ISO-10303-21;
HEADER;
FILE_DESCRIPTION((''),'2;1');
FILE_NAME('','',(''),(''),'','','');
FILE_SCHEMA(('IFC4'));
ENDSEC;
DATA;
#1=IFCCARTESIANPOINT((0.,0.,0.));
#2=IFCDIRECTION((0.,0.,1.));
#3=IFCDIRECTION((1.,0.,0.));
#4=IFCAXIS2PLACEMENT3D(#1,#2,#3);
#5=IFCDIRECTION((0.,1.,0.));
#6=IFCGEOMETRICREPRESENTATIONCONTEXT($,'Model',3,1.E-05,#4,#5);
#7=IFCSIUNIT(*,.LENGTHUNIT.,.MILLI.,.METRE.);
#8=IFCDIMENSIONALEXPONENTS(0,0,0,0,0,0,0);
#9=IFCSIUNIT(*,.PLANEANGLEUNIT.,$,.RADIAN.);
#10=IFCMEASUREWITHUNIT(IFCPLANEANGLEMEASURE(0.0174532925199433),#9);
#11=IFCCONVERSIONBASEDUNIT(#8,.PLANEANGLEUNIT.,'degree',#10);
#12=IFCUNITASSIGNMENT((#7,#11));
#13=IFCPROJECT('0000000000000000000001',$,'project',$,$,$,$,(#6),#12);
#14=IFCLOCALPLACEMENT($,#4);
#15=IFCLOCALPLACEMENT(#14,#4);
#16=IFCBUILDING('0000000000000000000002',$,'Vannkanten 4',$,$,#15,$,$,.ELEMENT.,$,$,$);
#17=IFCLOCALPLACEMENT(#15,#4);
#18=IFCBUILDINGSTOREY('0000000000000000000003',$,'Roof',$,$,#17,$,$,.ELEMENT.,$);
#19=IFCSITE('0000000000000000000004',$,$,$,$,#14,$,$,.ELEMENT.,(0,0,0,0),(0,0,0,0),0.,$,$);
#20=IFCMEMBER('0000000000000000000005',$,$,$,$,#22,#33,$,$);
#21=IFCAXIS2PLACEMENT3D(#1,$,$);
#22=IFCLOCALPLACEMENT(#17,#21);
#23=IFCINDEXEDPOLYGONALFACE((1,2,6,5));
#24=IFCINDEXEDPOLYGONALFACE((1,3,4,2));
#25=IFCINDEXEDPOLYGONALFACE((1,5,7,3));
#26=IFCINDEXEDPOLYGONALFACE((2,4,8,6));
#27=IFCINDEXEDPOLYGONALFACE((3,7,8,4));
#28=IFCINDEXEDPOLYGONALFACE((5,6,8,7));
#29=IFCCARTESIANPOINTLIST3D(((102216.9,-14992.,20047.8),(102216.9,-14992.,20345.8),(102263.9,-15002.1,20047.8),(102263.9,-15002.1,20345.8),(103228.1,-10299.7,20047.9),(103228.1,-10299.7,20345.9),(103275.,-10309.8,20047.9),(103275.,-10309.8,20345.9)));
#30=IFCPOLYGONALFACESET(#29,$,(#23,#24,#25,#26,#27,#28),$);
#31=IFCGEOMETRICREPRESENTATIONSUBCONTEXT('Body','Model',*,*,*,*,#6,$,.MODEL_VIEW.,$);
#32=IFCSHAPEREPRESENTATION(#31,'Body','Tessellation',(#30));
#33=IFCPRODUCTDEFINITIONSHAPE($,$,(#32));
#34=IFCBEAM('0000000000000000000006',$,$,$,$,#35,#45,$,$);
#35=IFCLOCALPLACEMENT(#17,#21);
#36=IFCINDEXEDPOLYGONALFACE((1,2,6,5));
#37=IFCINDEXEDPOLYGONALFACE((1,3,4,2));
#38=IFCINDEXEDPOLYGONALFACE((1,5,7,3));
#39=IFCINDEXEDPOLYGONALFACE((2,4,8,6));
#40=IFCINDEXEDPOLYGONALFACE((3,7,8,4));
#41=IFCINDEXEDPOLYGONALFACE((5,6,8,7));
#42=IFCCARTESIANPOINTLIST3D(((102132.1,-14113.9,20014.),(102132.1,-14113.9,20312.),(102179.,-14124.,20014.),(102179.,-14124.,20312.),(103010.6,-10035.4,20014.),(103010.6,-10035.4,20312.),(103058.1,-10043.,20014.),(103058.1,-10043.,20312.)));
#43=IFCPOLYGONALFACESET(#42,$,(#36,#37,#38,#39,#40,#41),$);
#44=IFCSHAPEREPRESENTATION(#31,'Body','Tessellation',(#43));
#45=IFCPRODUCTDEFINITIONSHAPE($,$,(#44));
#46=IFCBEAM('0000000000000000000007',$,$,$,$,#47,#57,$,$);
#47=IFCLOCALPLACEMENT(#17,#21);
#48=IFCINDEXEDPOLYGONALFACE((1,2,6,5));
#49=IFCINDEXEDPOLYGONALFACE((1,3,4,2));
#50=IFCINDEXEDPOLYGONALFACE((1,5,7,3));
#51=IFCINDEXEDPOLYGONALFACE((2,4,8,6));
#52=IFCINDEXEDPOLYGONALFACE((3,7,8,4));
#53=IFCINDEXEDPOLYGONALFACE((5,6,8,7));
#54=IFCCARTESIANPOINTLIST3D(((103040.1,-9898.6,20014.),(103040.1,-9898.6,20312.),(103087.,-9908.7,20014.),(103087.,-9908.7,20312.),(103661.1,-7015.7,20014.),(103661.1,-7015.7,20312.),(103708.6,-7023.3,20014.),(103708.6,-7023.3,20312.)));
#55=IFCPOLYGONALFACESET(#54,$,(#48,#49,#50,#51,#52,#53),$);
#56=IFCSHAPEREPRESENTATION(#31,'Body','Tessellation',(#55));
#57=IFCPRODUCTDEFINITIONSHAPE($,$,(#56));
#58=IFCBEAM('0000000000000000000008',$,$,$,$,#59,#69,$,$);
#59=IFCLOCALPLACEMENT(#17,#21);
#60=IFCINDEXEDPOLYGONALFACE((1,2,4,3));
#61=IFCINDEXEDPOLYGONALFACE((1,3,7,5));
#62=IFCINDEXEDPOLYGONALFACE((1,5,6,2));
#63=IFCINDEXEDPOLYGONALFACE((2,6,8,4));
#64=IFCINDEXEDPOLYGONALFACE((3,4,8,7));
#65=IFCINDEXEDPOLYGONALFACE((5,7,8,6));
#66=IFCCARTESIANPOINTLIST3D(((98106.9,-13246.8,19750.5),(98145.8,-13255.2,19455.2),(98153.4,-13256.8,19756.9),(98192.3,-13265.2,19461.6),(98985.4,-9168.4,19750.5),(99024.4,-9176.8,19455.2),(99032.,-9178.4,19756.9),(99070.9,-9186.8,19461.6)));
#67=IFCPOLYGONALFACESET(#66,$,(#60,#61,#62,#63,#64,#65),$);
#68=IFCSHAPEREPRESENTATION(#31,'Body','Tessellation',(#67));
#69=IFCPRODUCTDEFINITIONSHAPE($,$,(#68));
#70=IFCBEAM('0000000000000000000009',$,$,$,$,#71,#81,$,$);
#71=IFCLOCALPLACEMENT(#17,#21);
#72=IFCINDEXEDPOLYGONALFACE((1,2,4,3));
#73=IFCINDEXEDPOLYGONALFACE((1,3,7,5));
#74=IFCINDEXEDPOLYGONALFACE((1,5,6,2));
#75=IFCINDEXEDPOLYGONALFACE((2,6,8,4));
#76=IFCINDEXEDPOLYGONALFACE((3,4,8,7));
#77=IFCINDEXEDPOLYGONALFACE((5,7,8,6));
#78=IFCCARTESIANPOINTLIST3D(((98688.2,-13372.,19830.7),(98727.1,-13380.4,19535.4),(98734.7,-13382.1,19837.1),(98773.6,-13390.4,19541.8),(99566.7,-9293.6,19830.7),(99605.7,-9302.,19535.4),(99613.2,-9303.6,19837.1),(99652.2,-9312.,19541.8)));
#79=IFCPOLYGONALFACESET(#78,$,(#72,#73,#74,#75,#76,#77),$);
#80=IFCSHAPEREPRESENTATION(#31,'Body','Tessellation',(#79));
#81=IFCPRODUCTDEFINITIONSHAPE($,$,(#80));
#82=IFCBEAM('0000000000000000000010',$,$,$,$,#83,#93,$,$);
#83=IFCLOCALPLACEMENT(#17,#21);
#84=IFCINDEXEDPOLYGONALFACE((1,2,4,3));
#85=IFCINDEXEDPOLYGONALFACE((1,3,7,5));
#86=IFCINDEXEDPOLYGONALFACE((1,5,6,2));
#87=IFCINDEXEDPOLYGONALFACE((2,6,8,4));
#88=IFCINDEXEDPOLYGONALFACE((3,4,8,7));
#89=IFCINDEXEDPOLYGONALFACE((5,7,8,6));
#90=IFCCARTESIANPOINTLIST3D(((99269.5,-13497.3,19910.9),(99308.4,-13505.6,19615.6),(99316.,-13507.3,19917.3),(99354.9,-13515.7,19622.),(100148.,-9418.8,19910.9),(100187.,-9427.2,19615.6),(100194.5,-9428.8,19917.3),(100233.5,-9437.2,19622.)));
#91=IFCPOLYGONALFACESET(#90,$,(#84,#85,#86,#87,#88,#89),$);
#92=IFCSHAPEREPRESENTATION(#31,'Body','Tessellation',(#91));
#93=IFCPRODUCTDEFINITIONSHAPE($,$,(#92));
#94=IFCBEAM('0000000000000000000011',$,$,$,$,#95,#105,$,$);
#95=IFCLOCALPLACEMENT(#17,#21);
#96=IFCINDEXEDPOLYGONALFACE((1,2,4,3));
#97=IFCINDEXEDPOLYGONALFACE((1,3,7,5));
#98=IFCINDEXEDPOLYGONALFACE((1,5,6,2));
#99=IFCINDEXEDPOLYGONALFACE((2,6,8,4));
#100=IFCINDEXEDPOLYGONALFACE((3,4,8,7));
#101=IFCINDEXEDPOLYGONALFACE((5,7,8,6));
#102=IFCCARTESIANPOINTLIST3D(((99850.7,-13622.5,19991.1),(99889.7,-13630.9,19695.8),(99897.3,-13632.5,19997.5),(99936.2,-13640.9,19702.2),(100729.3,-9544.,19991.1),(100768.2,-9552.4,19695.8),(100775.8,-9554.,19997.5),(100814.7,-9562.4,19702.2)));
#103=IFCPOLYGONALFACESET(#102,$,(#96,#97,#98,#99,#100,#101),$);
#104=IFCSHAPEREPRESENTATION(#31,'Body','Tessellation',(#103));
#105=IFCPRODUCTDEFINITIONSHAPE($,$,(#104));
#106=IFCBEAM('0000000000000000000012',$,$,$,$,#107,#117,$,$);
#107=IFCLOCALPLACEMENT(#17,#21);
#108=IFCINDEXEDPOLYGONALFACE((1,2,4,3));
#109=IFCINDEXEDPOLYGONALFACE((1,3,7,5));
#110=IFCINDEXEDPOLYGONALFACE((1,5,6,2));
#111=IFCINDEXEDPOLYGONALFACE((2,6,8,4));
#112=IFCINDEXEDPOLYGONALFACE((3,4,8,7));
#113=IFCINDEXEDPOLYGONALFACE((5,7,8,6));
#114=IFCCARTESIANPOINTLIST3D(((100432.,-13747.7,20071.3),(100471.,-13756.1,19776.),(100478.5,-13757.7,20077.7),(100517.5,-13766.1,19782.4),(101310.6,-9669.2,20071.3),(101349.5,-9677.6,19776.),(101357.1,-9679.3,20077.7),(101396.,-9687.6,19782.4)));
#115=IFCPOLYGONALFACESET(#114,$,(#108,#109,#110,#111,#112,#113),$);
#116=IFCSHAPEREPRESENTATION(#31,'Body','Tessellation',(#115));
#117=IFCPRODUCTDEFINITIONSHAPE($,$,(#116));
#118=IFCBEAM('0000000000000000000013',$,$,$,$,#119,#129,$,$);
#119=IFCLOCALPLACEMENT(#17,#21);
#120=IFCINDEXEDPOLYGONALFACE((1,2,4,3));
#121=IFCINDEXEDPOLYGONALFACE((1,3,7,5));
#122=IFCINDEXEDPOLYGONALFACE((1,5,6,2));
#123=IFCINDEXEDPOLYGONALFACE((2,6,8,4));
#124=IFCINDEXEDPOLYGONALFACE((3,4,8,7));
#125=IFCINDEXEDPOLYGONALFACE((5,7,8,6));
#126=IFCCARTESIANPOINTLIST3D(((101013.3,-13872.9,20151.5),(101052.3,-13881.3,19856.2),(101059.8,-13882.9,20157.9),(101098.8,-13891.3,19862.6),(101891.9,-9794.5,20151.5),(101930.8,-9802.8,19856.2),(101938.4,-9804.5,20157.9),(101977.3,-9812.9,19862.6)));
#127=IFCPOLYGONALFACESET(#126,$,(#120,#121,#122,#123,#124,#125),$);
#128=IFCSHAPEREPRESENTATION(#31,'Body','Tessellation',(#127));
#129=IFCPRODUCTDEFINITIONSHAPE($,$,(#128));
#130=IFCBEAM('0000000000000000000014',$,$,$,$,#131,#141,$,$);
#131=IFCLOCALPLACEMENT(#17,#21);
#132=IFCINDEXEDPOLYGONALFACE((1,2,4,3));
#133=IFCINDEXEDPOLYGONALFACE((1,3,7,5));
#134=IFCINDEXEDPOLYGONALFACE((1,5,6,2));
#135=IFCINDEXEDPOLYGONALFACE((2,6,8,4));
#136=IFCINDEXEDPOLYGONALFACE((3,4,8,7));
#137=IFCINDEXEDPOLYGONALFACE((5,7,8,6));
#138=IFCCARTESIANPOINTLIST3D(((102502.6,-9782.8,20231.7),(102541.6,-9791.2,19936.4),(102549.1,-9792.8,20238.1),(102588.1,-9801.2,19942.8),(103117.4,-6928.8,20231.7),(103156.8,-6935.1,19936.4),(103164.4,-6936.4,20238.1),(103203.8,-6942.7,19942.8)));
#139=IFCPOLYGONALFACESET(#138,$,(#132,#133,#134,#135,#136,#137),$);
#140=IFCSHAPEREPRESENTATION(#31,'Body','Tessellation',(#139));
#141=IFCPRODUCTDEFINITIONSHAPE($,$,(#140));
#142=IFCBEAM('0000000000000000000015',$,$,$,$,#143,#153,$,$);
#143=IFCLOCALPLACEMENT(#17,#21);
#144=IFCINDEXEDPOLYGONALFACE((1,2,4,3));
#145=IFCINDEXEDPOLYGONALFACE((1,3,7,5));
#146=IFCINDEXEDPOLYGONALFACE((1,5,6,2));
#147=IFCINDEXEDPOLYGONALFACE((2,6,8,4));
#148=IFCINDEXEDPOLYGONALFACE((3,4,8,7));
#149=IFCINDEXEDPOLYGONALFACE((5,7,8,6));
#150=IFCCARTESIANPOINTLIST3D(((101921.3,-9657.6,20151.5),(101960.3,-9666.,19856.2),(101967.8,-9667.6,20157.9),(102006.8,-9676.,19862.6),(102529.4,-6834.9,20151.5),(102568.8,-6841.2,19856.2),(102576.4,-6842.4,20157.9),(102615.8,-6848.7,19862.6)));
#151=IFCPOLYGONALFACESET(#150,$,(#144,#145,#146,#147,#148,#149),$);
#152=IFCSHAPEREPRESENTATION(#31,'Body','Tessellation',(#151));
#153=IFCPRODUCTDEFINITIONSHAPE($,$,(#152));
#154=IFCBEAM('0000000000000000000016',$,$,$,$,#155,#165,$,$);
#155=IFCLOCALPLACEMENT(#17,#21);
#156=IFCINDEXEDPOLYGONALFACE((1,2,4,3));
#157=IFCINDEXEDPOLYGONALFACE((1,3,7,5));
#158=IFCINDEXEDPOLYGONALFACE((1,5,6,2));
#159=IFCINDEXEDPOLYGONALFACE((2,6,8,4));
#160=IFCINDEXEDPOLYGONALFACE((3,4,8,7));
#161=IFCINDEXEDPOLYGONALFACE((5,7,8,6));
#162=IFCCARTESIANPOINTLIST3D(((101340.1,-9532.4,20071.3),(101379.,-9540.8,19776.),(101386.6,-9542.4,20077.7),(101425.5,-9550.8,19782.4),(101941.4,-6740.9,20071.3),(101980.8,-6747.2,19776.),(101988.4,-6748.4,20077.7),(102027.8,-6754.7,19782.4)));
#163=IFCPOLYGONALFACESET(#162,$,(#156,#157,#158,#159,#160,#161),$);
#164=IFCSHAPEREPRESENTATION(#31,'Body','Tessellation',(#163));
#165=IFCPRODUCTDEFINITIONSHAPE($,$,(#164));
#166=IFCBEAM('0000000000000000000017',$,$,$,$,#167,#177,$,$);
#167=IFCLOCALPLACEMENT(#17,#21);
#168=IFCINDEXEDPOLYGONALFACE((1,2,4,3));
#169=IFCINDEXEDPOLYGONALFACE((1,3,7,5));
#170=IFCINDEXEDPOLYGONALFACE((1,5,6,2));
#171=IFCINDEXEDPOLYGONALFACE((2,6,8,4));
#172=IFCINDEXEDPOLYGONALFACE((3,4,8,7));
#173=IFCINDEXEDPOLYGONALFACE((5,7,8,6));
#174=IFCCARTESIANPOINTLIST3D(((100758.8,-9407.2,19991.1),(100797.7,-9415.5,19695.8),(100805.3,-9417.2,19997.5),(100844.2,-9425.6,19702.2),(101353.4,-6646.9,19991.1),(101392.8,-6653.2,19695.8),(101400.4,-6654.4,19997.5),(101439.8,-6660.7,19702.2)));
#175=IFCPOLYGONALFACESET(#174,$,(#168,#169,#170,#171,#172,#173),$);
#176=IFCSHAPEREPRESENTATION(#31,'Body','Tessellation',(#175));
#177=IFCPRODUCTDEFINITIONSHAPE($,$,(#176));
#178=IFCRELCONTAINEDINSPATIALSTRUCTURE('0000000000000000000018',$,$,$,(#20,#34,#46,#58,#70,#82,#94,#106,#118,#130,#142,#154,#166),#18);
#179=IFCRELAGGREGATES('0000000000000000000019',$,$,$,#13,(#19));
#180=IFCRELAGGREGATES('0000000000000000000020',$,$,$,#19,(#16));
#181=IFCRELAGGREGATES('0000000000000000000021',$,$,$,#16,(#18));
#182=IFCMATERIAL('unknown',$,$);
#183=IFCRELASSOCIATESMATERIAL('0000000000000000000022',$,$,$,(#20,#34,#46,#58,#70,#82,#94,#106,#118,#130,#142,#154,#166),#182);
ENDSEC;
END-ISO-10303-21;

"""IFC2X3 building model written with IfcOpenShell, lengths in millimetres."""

from ifc_helpers import new_model, entity, si_unit, converted_unit, direction, frame, origin_with_axes, place, context, subcontext, project, spatial, polyline, segment, composite_curve, outline, extrude, clip, halfspace, material, element, save


model = new_model("IFC2X3")

# Units and contexts
model_context = context("Model", 3, precision=1e-05, world=origin_with_axes(), true_north=direction((0.0, 1.0, 0.0)))
body_context = subcontext(model_context, "Body", "Model", "MODEL_VIEW")
ifc_project = project(units=[si_unit("LENGTHUNIT", "METRE", prefix="MILLI"), converted_unit("PLANEANGLEUNIT", "degree", entity("IfcPlaneAngleMeasure", 0.0174532925199433), si_unit("PLANEANGLEUNIT", "RADIAN"), dimensions=[0, 0, 0, 0, 0, 0, 0])], contexts=[model_context])

# Site, building, storey
site_placement = place(None, origin_with_axes())
site = spatial("IfcSite", under=ifc_project, at=site_placement, CompositionType="ELEMENT", RefLatitude=(0, 0, 0, 0), RefLongitude=(0, 0, 0, 0), RefElevation=0.0)
building_placement = place(site_placement, origin_with_axes())
building = spatial("IfcBuilding", under=site, at=building_placement, Name="Vannkanten 4", CompositionType="ELEMENT")
storey_placement = place(building_placement, origin_with_axes())
storey = spatial("IfcBuildingStorey", under=building, at=storey_placement, Name="Roof", CompositionType="ELEMENT")

# Member
ifc_material = material(Name="unknown")
member_1_placement = place(storey_placement, frame((103251.6, -10304.7, 20196.9), z_axis=(-0.210663, -0.977559, -0.000011), x_axis=(0.977559, -0.210663, 0.0)))
element("IfcMember", 1, at=member_1_placement, inside=storey, material=ifc_material, context=body_context, shape_type="SweptSolid", body=[
    extrude(outline(composite_curve([segment(polyline([(-24.0, -149.0), (-24.0, 149.0), (24.0, 149.0), (24.0, -149.0), (-24.0, -149.0)]), True, "CONTINUOUS")], self_intersect=False)), frame((0.0, 0.0, 0.0), z_axis=(0.0, 0.0, 1.0), x_axis=(1.0, 0.0, 0.0)), (0.0, 0.0, 1.0), 4800.0),
])

# Beams
beam_1_placement = place(storey_placement, frame((103034.4, -10039.2, 20163.0), z_axis=(-0.210582, -0.977576, 0.0), x_axis=(0.977576, -0.210582, 0.0)))
element("IfcBeam", 2, at=beam_1_placement, inside=storey, material=ifc_material, context=body_context, shape_type="Clipping", body=[
    clip(extrude(outline(composite_curve([segment(polyline([(-24.0, -149.0), (-24.0, 149.0), (24.0, 149.0), (24.0, -149.0), (-24.0, -149.0)]), True, "CONTINUOUS")], self_intersect=False)), frame((0.0, 0.0, -2088.6), z_axis=(0.0, 0.0, 1.0), x_axis=(1.0, 0.0, 0.0)), (0.0, 0.0, 1.0), 6261.9), halfspace(frame((-24.0, 149.0, 1.3), z_axis=(0.053649, 0.0, 0.99856), x_axis=(0.99856, 0.0, -0.053649)), True)),
])
beam_2_placement = place(storey_placement, frame((103684.8, -7019.5, 20163.0), z_axis=(-0.210582, -0.977576, 0.0), x_axis=(0.977576, -0.210582, 0.0)))
element("IfcBeam", 3, at=beam_2_placement, inside=storey, material=ifc_material, context=body_context, shape_type="Clipping", body=[
    clip(extrude(outline(composite_curve([segment(polyline([(-24.0, -149.0), (-24.0, 149.0), (24.0, 149.0), (24.0, -149.0), (-24.0, -149.0)]), True, "CONTINUOUS")], self_intersect=False)), frame((0.0, 0.0, -1477.1), z_axis=(0.0, 0.0, 1.0), x_axis=(1.0, 0.0, 0.0)), (0.0, 0.0, 1.0), 4427.3), halfspace(frame((-24.0, 149.0, 1.3), z_axis=(0.053649, 0.0, 0.99856), x_axis=(0.99856, 0.0, -0.053649)), True)),
])
beam_3_placement = place(storey_placement, frame((98149.6, -13256.0, 19606.0), z_axis=(0.210582, 0.977576, 0.0), x_axis=(-0.968803, 0.208692, -0.133675)))
element("IfcBeam", 4, at=beam_3_placement, inside=storey, material=ifc_material, context=body_context, shape_type="SweptSolid", body=[
    extrude(outline(composite_curve([segment(polyline([(-24.0, -149.0), (-24.0, 149.0), (24.0, 149.0), (24.0, -149.0), (-24.0, -149.0)]), True, "CONTINUOUS")], self_intersect=False)), frame((0.0, 0.0, 0.0), z_axis=(0.0, 0.0, 1.0), x_axis=(1.0, 0.0, 0.0)), (0.0, 0.0, 1.0), 4172.0),
])
beam_4_placement = place(storey_placement, frame((98730.9, -13381.2, 19686.2), z_axis=(0.210582, 0.977576, 0.0), x_axis=(-0.968803, 0.208692, -0.133675)))
element("IfcBeam", 5, at=beam_4_placement, inside=storey, material=ifc_material, context=body_context, shape_type="SweptSolid", body=[
    extrude(outline(composite_curve([segment(polyline([(-24.0, -149.0), (-24.0, 149.0), (24.0, 149.0), (24.0, -149.0), (-24.0, -149.0)]), True, "CONTINUOUS")], self_intersect=False)), frame((0.0, 0.0, 0.0), z_axis=(0.0, 0.0, 1.0), x_axis=(1.0, 0.0, 0.0)), (0.0, 0.0, 1.0), 4172.0),
])
beam_5_placement = place(storey_placement, frame((99312.2, -13506.5, 19766.5), z_axis=(0.210582, 0.977576, 0.0), x_axis=(-0.968803, 0.208692, -0.133675)))
element("IfcBeam", 6, at=beam_5_placement, inside=storey, material=ifc_material, context=body_context, shape_type="SweptSolid", body=[
    extrude(outline(composite_curve([segment(polyline([(-24.0, -149.0), (-24.0, 149.0), (24.0, 149.0), (24.0, -149.0), (-24.0, -149.0)]), True, "CONTINUOUS")], self_intersect=False)), frame((0.0, 0.0, 0.0), z_axis=(0.0, 0.0, 1.0), x_axis=(1.0, 0.0, 0.0)), (0.0, 0.0, 1.0), 4172.0),
])
beam_6_placement = place(storey_placement, frame((99893.5, -13631.7, 19846.7), z_axis=(0.210582, 0.977576, 0.0), x_axis=(-0.968803, 0.208692, -0.133675)))
element("IfcBeam", 7, at=beam_6_placement, inside=storey, material=ifc_material, context=body_context, shape_type="SweptSolid", body=[
    extrude(outline(composite_curve([segment(polyline([(-24.0, -149.0), (-24.0, 149.0), (24.0, 149.0), (24.0, -149.0), (-24.0, -149.0)]), True, "CONTINUOUS")], self_intersect=False)), frame((0.0, 0.0, 0.0), z_axis=(0.0, 0.0, 1.0), x_axis=(1.0, 0.0, 0.0)), (0.0, 0.0, 1.0), 4172.0),
])
beam_7_placement = place(storey_placement, frame((100474.8, -13756.9, 19926.9), z_axis=(0.210582, 0.977576, 0.0), x_axis=(-0.968803, 0.208692, -0.133675)))
element("IfcBeam", 8, at=beam_7_placement, inside=storey, material=ifc_material, context=body_context, shape_type="SweptSolid", body=[
    extrude(outline(composite_curve([segment(polyline([(-24.0, -149.0), (-24.0, 149.0), (24.0, 149.0), (24.0, -149.0), (-24.0, -149.0)]), True, "CONTINUOUS")], self_intersect=False)), frame((0.0, 0.0, 0.0), z_axis=(0.0, 0.0, 1.0), x_axis=(1.0, 0.0, 0.0)), (0.0, 0.0, 1.0), 4172.0),
])
beam_8_placement = place(storey_placement, frame((101056.0, -13882.1, 20007.1), z_axis=(0.210582, 0.977576, 0.0), x_axis=(-0.968803, 0.208692, -0.133675)))
element("IfcBeam", 9, at=beam_8_placement, inside=storey, material=ifc_material, context=body_context, shape_type="SweptSolid", body=[
    extrude(outline(composite_curve([segment(polyline([(-24.0, -149.0), (-24.0, 149.0), (24.0, 149.0), (24.0, -149.0), (-24.0, -149.0)]), True, "CONTINUOUS")], self_intersect=False)), frame((0.0, 0.0, 0.0), z_axis=(0.0, 0.0, 1.0), x_axis=(1.0, 0.0, 0.0)), (0.0, 0.0, 1.0), 4172.0),
])
beam_9_placement = place(storey_placement, frame((102545.3, -9792.0, 20087.3), z_axis=(0.210582, 0.977576, 0.0), x_axis=(-0.968803, 0.208692, -0.133675)))
element("IfcBeam", 10, at=beam_9_placement, inside=storey, material=ifc_material, context=body_context, shape_type="Clipping", body=[
    clip(extrude(outline(composite_curve([segment(polyline([(-24.0, -149.0), (-24.0, 149.0), (24.0, 149.0), (24.0, -149.0), (-24.0, -149.0)]), True, "CONTINUOUS")], self_intersect=False)), frame((0.0, 0.0, 0.0), z_axis=(0.0, 0.0, 1.0), x_axis=(1.0, 0.0, 0.0)), (0.0, 0.0, 1.0), 4386.2), halfspace(frame((-24.0, -149.0, 2924.1), z_axis=(-0.053168, -0.007172, -0.99856), x_axis=(-0.998586, 0.0, 0.053169)), True)),
])
beam_10_placement = place(storey_placement, frame((101964.1, -9666.8, 20007.1), z_axis=(0.210582, 0.977576, 0.0), x_axis=(-0.968803, 0.208692, -0.133675)))
element("IfcBeam", 11, at=beam_10_placement, inside=storey, material=ifc_material, context=body_context, shape_type="Clipping", body=[
    clip(extrude(outline(composite_curve([segment(polyline([(-24.0, -149.0), (-24.0, 149.0), (24.0, 149.0), (24.0, -149.0), (-24.0, -149.0)]), True, "CONTINUOUS")], self_intersect=False)), frame((0.0, 0.0, 0.0), z_axis=(0.0, 0.0, 1.0), x_axis=(1.0, 0.0, 0.0)), (0.0, 0.0, 1.0), 4338.3), halfspace(frame((-24.0, -149.0, 2892.2), z_axis=(-0.053168, -0.007172, -0.99856), x_axis=(-0.998586, 0.0, 0.053169)), True)),
])
beam_11_placement = place(storey_placement, frame((101382.8, -9541.6, 19926.9), z_axis=(0.210582, 0.977576, 0.0), x_axis=(-0.968803, 0.208692, -0.133675)))
element("IfcBeam", 12, at=beam_11_placement, inside=storey, material=ifc_material, context=body_context, shape_type="Clipping", body=[
    clip(extrude(outline(composite_curve([segment(polyline([(-24.0, -149.0), (-24.0, 149.0), (24.0, 149.0), (24.0, -149.0), (-24.0, -149.0)]), True, "CONTINUOUS")], self_intersect=False)), frame((0.0, 0.0, 0.0), z_axis=(0.0, 0.0, 1.0), x_axis=(1.0, 0.0, 0.0)), (0.0, 0.0, 1.0), 4290.3), halfspace(frame((-24.0, -149.0, 2860.2), z_axis=(-0.053168, -0.007172, -0.99856), x_axis=(-0.998586, 0.0, 0.053169)), True)),
])
beam_12_placement = place(storey_placement, frame((100801.5, -9416.4, 19846.7), z_axis=(0.210582, 0.977576, 0.0), x_axis=(-0.968803, 0.208692, -0.133675)))
element("IfcBeam", 13, at=beam_12_placement, inside=storey, material=ifc_material, context=body_context, shape_type="Clipping", body=[
    clip(extrude(outline(composite_curve([segment(polyline([(-24.0, -149.0), (-24.0, 149.0), (24.0, 149.0), (24.0, -149.0), (-24.0, -149.0)]), True, "CONTINUOUS")], self_intersect=False)), frame((0.0, 0.0, 0.0), z_axis=(0.0, 0.0, 1.0), x_axis=(1.0, 0.0, 0.0)), (0.0, 0.0, 1.0), 4242.4), halfspace(frame((-24.0, -149.0, 2828.3), z_axis=(-0.053168, -0.007172, -0.99856), x_axis=(-0.998586, 0.0, 0.053169)), True)),
])

save(model, "model.ifc")
